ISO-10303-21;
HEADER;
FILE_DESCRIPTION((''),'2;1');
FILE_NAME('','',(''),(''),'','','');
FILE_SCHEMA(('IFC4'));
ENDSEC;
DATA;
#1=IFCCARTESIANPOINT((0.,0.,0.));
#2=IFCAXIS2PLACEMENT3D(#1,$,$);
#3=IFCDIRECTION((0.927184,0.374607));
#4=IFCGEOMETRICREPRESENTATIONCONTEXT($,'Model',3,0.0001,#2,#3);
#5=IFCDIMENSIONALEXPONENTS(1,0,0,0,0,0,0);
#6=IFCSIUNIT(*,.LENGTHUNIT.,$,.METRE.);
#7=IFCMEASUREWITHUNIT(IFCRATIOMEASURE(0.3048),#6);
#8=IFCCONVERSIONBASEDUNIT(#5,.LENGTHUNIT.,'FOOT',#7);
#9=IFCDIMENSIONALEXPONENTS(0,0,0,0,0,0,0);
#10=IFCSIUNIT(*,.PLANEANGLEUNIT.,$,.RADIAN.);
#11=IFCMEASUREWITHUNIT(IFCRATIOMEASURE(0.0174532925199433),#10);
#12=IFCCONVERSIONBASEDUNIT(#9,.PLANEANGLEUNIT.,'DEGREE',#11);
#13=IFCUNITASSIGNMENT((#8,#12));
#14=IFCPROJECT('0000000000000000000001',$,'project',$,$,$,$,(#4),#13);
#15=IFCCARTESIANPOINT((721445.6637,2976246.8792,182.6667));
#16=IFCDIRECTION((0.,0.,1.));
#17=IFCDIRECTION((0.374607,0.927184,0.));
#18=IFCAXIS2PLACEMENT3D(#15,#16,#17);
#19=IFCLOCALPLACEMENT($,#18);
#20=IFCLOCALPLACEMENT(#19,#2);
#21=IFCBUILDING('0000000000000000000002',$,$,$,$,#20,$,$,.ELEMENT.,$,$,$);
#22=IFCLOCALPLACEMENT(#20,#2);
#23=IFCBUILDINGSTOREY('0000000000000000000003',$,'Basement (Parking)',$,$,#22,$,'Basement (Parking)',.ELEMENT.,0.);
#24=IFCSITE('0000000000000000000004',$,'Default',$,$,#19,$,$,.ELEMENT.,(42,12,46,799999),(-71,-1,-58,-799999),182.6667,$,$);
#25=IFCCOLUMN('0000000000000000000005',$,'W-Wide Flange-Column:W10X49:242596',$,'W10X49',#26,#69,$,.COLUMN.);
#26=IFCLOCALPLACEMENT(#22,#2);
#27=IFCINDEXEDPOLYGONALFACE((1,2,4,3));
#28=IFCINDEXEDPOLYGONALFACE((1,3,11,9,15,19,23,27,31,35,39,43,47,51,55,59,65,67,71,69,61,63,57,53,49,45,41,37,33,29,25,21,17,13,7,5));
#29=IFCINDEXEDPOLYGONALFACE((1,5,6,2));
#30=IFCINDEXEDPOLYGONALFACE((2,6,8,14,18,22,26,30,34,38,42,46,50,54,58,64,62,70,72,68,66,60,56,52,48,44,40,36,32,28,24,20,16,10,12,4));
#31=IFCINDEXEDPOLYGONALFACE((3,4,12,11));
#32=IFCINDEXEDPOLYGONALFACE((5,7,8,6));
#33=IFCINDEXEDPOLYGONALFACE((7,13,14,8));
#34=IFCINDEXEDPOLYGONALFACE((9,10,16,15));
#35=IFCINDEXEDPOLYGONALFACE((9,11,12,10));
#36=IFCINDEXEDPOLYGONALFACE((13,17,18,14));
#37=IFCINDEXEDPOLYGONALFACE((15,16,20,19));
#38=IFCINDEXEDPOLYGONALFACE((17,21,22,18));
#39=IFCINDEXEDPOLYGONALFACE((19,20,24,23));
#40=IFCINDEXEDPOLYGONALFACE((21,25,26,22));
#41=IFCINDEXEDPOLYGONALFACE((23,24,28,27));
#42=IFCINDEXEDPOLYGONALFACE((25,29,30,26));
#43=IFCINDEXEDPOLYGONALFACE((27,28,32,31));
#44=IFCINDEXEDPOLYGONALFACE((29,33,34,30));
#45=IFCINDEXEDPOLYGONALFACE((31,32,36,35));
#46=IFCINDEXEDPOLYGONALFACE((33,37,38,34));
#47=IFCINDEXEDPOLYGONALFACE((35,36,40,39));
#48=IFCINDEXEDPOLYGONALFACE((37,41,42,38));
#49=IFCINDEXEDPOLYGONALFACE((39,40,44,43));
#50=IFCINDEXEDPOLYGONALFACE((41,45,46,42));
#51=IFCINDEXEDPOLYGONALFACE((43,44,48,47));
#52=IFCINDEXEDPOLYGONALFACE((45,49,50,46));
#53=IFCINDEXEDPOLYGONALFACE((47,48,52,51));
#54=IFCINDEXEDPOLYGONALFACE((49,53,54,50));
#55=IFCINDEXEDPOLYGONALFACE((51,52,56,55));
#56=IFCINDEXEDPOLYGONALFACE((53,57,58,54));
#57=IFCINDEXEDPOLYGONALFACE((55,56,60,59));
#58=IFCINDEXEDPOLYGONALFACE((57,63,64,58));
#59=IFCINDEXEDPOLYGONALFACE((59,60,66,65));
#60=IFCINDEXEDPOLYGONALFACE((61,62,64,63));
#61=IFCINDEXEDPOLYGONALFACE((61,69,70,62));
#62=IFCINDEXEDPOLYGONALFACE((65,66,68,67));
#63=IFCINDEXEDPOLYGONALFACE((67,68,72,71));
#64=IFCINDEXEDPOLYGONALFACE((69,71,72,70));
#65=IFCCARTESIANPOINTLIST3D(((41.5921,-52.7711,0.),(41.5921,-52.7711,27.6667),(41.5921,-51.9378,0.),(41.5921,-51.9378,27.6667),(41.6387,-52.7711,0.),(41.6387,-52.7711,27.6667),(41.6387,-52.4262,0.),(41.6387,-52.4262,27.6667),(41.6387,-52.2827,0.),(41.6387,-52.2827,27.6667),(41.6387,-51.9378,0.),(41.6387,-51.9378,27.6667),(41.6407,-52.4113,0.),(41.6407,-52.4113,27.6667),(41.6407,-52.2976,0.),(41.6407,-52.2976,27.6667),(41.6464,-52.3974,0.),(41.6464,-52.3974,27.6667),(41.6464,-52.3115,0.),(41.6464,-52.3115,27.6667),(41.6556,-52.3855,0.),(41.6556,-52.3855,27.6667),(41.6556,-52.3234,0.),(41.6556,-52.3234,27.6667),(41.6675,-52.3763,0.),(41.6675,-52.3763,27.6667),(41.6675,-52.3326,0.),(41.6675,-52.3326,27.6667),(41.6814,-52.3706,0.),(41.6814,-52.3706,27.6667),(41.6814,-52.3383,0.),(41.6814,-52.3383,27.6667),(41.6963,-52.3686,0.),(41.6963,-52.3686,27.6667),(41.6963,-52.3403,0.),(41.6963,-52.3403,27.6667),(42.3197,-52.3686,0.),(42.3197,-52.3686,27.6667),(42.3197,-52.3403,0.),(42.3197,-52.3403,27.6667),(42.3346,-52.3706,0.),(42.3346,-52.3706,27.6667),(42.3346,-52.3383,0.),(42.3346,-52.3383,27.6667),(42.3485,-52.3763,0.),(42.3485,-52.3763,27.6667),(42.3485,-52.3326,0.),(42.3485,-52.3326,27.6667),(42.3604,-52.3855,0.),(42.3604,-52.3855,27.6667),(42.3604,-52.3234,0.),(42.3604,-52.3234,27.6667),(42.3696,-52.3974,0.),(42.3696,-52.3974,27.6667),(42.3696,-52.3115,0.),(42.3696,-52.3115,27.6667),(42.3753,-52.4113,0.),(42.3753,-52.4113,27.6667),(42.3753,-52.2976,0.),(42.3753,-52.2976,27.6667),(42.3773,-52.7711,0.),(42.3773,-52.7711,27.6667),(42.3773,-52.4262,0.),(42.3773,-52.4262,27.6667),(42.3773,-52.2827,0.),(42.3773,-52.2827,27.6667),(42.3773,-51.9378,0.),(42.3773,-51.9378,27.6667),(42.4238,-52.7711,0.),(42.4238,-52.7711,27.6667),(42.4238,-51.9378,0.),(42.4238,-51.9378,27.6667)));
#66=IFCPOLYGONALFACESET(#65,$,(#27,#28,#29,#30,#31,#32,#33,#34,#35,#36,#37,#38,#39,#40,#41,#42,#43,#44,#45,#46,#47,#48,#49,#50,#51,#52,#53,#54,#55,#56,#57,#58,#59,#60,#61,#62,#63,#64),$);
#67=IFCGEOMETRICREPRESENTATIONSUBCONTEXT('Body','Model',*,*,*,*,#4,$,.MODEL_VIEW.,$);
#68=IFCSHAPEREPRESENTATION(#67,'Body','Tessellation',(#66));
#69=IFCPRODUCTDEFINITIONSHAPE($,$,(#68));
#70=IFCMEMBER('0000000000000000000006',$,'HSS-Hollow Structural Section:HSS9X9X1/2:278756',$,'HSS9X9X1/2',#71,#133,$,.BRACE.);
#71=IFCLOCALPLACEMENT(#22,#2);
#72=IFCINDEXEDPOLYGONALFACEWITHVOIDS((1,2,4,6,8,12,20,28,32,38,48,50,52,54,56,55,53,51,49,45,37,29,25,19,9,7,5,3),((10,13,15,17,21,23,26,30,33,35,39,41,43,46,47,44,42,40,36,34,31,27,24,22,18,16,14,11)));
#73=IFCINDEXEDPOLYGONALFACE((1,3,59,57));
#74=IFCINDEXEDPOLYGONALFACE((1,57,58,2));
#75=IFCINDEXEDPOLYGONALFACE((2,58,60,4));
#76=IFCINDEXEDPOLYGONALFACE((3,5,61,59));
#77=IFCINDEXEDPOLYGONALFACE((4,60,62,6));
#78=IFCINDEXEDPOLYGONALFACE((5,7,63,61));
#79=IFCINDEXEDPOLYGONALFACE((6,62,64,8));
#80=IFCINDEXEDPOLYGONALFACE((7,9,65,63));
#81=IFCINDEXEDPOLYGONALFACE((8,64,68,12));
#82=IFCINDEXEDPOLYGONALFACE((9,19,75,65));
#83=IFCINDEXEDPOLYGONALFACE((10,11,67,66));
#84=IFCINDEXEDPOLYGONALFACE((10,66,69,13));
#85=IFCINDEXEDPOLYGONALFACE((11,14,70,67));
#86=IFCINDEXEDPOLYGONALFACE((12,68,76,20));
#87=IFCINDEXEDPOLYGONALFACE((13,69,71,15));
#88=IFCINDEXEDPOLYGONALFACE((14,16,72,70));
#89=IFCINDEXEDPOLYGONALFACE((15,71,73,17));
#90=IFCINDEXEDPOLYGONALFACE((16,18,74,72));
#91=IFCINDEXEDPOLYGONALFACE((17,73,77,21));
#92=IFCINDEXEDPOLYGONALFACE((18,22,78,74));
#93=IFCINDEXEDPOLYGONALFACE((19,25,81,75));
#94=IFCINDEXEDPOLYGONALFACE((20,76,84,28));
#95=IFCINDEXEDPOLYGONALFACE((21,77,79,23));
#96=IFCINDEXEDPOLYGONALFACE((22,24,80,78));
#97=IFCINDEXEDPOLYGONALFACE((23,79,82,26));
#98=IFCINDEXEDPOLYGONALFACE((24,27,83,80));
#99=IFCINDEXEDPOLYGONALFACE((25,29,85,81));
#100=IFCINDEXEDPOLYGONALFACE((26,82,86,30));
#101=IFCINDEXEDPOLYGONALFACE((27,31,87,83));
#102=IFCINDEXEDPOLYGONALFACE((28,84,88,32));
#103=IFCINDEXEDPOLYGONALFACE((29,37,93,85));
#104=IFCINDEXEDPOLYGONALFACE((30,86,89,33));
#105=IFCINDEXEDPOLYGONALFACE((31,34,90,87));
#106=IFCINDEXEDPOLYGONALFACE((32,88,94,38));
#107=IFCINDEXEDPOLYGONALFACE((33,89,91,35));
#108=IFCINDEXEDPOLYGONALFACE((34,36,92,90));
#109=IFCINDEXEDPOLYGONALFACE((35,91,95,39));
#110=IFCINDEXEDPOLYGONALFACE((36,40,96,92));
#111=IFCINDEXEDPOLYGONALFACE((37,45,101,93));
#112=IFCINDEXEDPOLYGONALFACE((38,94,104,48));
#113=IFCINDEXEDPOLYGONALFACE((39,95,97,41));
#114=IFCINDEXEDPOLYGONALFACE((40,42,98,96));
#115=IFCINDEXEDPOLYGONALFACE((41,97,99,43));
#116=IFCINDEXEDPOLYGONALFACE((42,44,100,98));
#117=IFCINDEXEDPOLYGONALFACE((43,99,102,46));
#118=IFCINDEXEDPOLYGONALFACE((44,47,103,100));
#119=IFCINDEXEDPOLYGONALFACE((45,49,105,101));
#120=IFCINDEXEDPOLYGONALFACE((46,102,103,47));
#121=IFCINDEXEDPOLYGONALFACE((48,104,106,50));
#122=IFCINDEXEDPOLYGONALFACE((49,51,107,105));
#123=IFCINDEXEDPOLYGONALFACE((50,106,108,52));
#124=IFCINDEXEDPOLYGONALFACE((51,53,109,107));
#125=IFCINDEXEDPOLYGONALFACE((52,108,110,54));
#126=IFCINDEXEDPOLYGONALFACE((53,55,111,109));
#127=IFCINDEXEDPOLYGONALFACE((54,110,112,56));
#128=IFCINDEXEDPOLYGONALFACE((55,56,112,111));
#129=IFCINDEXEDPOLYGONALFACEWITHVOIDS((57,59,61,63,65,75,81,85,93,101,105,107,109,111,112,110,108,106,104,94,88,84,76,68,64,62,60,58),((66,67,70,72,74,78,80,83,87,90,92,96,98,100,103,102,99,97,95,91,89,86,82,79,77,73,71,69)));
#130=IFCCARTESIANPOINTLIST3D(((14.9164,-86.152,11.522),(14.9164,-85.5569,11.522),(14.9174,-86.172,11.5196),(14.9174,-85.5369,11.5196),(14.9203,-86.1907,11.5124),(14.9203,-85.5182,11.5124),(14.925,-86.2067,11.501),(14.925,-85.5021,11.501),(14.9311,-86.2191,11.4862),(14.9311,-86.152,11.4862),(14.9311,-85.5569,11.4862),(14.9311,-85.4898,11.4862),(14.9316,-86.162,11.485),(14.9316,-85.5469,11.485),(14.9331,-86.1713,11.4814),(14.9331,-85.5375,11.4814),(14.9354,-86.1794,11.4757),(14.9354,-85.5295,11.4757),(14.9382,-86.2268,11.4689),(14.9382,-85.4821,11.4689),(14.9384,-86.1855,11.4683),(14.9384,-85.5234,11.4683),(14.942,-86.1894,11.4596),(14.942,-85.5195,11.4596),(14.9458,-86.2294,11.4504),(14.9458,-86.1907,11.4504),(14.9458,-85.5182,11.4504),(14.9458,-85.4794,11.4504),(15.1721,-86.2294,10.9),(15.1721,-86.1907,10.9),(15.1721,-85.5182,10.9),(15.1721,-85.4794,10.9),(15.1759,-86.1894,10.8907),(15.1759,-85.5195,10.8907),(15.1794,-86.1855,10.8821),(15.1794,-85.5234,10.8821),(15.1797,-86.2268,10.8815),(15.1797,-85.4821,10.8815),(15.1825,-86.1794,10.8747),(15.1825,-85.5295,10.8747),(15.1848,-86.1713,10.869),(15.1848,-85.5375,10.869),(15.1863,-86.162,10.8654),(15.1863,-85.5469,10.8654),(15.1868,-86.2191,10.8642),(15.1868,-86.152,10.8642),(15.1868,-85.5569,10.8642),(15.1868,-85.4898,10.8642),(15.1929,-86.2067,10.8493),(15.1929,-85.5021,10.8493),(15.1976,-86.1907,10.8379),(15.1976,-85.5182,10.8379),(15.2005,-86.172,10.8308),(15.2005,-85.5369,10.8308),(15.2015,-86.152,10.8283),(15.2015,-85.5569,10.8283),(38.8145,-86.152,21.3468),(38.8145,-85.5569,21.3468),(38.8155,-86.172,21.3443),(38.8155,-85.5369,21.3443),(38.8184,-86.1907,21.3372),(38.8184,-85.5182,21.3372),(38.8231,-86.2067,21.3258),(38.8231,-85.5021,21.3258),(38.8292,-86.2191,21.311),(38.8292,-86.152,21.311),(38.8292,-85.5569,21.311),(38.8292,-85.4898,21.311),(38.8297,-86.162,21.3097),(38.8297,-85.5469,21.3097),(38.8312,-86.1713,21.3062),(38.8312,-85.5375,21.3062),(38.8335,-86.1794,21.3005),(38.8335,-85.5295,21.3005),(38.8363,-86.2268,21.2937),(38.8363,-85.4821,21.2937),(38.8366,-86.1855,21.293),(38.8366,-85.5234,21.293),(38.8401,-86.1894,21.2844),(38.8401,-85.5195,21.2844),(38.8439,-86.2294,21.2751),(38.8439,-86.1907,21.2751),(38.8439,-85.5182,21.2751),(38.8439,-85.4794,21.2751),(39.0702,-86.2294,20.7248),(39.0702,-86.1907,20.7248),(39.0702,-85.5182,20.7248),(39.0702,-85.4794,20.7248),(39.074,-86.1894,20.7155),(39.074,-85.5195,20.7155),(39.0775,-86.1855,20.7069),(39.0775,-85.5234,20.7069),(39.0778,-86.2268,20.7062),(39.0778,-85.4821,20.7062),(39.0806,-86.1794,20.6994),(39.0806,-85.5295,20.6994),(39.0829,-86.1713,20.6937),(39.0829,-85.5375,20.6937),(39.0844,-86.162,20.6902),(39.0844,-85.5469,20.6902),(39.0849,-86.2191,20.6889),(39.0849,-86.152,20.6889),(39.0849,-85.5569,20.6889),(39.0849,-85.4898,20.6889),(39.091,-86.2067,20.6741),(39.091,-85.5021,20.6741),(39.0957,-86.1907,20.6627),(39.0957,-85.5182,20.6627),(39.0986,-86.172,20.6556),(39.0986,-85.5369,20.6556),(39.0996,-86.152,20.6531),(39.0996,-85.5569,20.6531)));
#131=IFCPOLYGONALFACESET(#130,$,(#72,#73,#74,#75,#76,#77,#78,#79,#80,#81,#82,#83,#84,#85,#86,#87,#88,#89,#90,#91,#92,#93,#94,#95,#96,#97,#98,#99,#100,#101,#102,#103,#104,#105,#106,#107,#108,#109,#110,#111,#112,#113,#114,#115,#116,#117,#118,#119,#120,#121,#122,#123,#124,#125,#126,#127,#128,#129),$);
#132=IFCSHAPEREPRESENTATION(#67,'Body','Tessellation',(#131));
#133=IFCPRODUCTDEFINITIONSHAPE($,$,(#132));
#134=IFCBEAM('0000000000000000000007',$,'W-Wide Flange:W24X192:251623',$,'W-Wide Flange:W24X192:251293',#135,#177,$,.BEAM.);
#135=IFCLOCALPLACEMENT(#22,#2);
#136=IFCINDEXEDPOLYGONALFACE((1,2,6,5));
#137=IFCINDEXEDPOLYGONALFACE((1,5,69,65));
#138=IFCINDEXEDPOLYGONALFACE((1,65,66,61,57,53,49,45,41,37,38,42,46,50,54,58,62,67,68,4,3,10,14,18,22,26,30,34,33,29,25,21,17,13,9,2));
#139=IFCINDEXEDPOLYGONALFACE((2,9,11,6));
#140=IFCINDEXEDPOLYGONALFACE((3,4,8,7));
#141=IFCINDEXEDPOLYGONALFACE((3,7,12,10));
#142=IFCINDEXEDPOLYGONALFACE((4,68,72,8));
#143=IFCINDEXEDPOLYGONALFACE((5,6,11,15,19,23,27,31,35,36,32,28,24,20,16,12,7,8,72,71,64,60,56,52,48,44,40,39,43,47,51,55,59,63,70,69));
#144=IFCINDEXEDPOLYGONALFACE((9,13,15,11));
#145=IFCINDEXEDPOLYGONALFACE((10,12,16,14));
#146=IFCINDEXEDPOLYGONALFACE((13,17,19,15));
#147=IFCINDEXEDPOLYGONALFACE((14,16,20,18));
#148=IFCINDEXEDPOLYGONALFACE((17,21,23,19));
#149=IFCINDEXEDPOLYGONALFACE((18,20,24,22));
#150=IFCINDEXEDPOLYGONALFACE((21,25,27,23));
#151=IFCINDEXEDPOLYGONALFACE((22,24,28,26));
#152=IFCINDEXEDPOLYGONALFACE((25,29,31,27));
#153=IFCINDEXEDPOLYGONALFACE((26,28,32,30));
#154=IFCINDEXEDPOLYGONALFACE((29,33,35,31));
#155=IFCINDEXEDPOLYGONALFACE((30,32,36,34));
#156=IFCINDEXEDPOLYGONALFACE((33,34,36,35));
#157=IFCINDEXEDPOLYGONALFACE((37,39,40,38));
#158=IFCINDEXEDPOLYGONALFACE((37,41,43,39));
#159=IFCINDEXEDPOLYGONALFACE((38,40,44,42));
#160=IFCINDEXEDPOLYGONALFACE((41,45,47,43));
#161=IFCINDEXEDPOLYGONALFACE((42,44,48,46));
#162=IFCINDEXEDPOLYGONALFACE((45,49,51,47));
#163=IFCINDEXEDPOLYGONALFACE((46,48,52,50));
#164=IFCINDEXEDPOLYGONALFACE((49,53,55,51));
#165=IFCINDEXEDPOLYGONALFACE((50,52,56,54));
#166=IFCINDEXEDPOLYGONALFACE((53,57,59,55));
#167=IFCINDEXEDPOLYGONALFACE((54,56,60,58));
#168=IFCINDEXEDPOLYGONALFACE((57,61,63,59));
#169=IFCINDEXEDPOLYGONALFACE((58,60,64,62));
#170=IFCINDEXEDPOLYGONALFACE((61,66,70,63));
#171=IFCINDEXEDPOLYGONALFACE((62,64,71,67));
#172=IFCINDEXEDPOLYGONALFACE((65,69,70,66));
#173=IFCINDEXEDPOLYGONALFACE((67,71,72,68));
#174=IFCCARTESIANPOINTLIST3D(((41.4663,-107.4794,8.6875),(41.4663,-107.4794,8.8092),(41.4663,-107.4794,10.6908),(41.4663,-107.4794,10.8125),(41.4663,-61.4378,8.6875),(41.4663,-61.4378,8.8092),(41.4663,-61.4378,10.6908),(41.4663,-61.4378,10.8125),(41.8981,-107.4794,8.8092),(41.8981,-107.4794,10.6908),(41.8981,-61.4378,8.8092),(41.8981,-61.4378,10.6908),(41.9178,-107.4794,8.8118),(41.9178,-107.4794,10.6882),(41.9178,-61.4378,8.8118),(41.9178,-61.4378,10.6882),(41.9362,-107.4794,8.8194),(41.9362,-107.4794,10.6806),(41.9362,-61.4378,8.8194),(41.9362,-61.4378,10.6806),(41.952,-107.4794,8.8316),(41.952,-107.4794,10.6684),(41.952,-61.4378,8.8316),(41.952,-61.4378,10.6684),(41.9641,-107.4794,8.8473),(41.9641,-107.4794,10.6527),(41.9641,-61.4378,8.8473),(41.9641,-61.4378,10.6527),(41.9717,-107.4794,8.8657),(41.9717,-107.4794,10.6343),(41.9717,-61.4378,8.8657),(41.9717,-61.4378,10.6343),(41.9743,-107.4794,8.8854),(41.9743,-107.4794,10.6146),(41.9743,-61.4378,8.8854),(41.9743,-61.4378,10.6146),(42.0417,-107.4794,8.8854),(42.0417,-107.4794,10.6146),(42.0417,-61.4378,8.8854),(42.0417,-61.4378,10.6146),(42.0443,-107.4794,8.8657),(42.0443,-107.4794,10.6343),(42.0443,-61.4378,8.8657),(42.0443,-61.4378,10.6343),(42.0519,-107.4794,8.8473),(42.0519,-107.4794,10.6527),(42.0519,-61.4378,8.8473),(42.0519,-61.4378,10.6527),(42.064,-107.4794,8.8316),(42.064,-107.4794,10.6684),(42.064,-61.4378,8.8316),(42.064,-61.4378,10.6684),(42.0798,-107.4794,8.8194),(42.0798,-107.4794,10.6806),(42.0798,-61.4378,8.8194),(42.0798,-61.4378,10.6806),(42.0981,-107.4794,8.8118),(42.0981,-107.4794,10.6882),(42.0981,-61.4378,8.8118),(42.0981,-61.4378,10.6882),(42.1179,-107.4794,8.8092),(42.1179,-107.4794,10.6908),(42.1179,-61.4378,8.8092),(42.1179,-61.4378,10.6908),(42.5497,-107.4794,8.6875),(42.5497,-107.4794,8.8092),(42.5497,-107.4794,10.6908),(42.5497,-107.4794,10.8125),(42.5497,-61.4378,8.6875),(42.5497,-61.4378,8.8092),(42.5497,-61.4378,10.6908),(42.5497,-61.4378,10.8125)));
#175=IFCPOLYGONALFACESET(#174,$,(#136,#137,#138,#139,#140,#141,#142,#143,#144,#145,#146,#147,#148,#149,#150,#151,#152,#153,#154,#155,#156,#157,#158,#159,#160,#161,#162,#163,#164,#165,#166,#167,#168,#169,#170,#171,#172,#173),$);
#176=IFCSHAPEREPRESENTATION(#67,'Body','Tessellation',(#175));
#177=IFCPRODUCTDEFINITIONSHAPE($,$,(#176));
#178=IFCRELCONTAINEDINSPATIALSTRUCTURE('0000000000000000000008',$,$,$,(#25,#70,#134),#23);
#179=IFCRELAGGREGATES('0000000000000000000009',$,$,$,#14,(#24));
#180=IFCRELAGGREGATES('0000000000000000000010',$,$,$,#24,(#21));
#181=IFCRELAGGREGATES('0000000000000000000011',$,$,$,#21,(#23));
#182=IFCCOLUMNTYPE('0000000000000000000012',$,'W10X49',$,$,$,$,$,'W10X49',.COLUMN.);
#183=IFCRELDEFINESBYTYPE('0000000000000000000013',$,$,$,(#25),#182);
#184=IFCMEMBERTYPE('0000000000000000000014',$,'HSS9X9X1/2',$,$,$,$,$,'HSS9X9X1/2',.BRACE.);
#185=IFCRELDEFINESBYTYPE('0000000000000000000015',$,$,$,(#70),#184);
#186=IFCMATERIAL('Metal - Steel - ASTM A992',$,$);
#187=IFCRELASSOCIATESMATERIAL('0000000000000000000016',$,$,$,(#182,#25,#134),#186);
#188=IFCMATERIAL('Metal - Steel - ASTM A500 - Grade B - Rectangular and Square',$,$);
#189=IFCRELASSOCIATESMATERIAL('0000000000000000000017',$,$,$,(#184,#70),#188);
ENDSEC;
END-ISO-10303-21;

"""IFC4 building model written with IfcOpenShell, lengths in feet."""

from ifc_helpers import new_model, entity, si_unit, converted_unit, direction, frame, frame_2d, origin, place, context, subcontext, project, spatial, polyline, circle_curve, parameter, trimmed, segment, composite_curve, i_section, outline, extrude, source, transform, mapped, material, type_object, type_shapes, element, save


model = new_model("IFC4")

# Units and contexts
model_context = context("Model", 3, precision=0.0001, world=origin(), true_north=direction((0.927184, 0.374607)))
body_context = subcontext(model_context, "Body", "Model", "MODEL_VIEW")
ifc_project = project(units=[converted_unit("LENGTHUNIT", "FOOT", entity("IfcRatioMeasure", 0.3048), si_unit("LENGTHUNIT", "METRE"), dimensions=[1, 0, 0, 0, 0, 0, 0]), converted_unit("PLANEANGLEUNIT", "DEGREE", entity("IfcRatioMeasure", 0.0174532925199433), si_unit("PLANEANGLEUNIT", "RADIAN"), dimensions=[0, 0, 0, 0, 0, 0, 0])], contexts=[model_context])

# Site, building, storey
site_placement = place(None, frame((721445.6637, 2976246.8792, 182.6667), z_axis=(0.0, 0.0, 1.0), x_axis=(0.374607, 0.927184, 0.0)))
site = spatial("IfcSite", under=ifc_project, at=site_placement, Name="Default", CompositionType="ELEMENT", RefLatitude=(42, 12, 46, 799999), RefLongitude=(-71, -1, -58, -799999), RefElevation=182.6667)
building_placement = place(site_placement, origin())
building = spatial("IfcBuilding", under=site, at=building_placement, CompositionType="ELEMENT")
storey_placement = place(building_placement, origin())
storey = spatial("IfcBuildingStorey", under=building, at=storey_placement, Name="Basement (Parking)", LongName="Basement (Parking)", CompositionType="ELEMENT", Elevation=0.0)

# Column
ifc_material_1 = material(Name="Metal - Steel - ASTM A992")
column_type_1 = type_object("IfcColumnType", Name="W10X49", ElementType="W10X49", PredefinedType="COLUMN", material=ifc_material_1)
shared_shape_1 = source(origin(), body_context, "Body", "SweptSolid", [
    extrude(i_section(OverallWidth=0.8333, OverallDepth=0.8317, WebThickness=0.0283, FlangeThickness=0.0465, FilletRadius=0.0576, at=frame_2d((0.0, 0.0), x_axis=(0.0, 1.0))), frame((0.0, 0.0, 0.0), z_axis=(0.0, 0.0, 1.0), x_axis=(0.0, -1.0, 0.0)), (0.0, 0.0, 1.0), 27.6667),
])
type_shapes(column_type_1, [shared_shape_1])
column_placement = place(storey_placement, frame((42.008, -52.3544, 0.0), z_axis=(0.0, 0.0, 1.0), x_axis=(0.0, 1.0, 0.0)))
element("IfcColumn", 1, at=column_placement, inside=storey, type_object=column_type_1, material=ifc_material_1, Name="W-Wide Flange-Column:W10X49:242596", ObjectType="W10X49", PredefinedType="COLUMN", context=body_context, shape_type="MappedRepresentation", body=[
    mapped(shared_shape_1, transform((0.0, 0.0, 0.0), scale=1.0)),
])

# Member
ifc_material_2 = material(Name="Metal - Steel - ASTM A500 - Grade B - Rectangular and Square")
member_type = type_object("IfcMemberType", Name="HSS9X9X1/2", ElementType="HSS9X9X1/2", PredefinedType="BRACE", material=ifc_material_2)
shared_shape_2 = source(origin(), body_context, "Body", "SweptSolid", [
    extrude(outline(composite_curve([segment(trimmed(circle_curve(frame_2d((-0.2975, -0.2975), x_axis=(1.0, 0.0)), 0.0775), [parameter(180.0)], [parameter(270.0)], True, "PARAMETER"), True, "CONTINUOUS"), segment(polyline([(-0.2975, -0.375), (0.2975, -0.375)]), True, "CONTINUOUS"), segment(trimmed(circle_curve(frame_2d((0.2975, -0.2975), x_axis=(1.0, 0.0)), 0.0775), [parameter(270.0)], [parameter(0.0)], True, "PARAMETER"), True, "CONTINUOUS"), segment(polyline([(0.375, -0.2975), (0.375, 0.2975)]), True, "CONTINUOUS"), segment(trimmed(circle_curve(frame_2d((0.2975, 0.2975), x_axis=(1.0, 0.0)), 0.0775), [parameter(360.0)], [parameter(90.0)], True, "PARAMETER"), True, "CONTINUOUS"), segment(polyline([(0.2975, 0.375), (-0.2975, 0.375)]), True, "CONTINUOUS"), segment(trimmed(circle_curve(frame_2d((-0.2975, 0.2975), x_axis=(1.0, 0.0)), 0.0775), [parameter(90.0)], [parameter(180.0)], True, "PARAMETER"), True, "CONTINUOUS"), segment(polyline([(-0.375, 0.2975), (-0.375, -0.2975)]), True, "CONTINUOUS")], self_intersect=False), holes=[composite_curve([segment(polyline([(0.2975, -0.3363), (-0.2975, -0.3363)]), True, "CONTINUOUS"), segment(trimmed(circle_curve(frame_2d((-0.2975, -0.2975), x_axis=(1.0, 0.0)), 0.0387), [parameter(180.0)], [parameter(270.0)], True, "PARAMETER"), False, "CONTINUOUS"), segment(polyline([(-0.3363, -0.2975), (-0.3363, 0.2975)]), True, "CONTINUOUS"), segment(trimmed(circle_curve(frame_2d((-0.2975, 0.2975), x_axis=(1.0, 0.0)), 0.0387), [parameter(90.0)], [parameter(180.0)], True, "PARAMETER"), False, "CONTINUOUS"), segment(polyline([(-0.2975, 0.3363), (0.2975, 0.3363)]), True, "CONTINUOUS"), segment(trimmed(circle_curve(frame_2d((0.2975, 0.2975), x_axis=(1.0, 0.0)), 0.0387), [parameter(0.0)], [parameter(90.0)], True, "PARAMETER"), False, "CONTINUOUS"), segment(polyline([(0.3363, 0.2975), (0.3363, -0.2975)]), True, "CONTINUOUS"), segment(trimmed(circle_curve(frame_2d((0.2975, -0.2975), x_axis=(1.0, 0.0)), 0.0387), [parameter(270.0)], [parameter(0.0)], True, "PARAMETER"), False, "CONTINUOUS")], self_intersect=False)]), frame((-12.9194, 0.0, 0.0), z_axis=(1.0, 0.0, 0.0), x_axis=(0.0, -1.0, 0.0)), (0.0, 0.0, 1.0), 25.8388),
])
type_shapes(member_type, [shared_shape_2])
member_placement = place(storey_placement, frame((27.008, -85.8544, 16.0876), z_axis=(-0.380233, 0.0, 0.924891), x_axis=(0.924891, 0.0, 0.380233)))
element("IfcMember", 2, at=member_placement, inside=storey, type_object=member_type, material=ifc_material_2, Name="HSS-Hollow Structural Section:HSS9X9X1/2:278756", ObjectType="HSS9X9X1/2", PredefinedType="BRACE", context=body_context, shape_type="MappedRepresentation", body=[
    mapped(shared_shape_2, transform((0.0, 0.0, 0.0), scale=1.0)),
])

# Beam
beam_1_placement = place(storey_placement, frame((42.008, -109.3961, 10.8125), z_axis=(0.0, 0.0, 1.0), x_axis=(0.0, 1.0, 0.0)))
element("IfcBeam", 3, at=beam_1_placement, inside=storey, material=ifc_material_1, Name="W-Wide Flange:W24X192:251623", ObjectType="W-Wide Flange:W24X192:251293", PredefinedType="BEAM", context=body_context, shape_type="SweptSolid", body=[
    extrude(i_section(OverallWidth=1.0833, OverallDepth=2.125, WebThickness=0.0674, FlangeThickness=0.1217, FilletRadius=0.0762, at=frame_2d((0.0, 0.0), x_axis=(0.0, 1.0))), frame((1.9167, 0.0, -1.0625), z_axis=(1.0, 0.0, 0.0), x_axis=(0.0, 0.0, -1.0)), (0.0, 0.0, 1.0), 46.0417),
])

save(model, "model.ifc")
